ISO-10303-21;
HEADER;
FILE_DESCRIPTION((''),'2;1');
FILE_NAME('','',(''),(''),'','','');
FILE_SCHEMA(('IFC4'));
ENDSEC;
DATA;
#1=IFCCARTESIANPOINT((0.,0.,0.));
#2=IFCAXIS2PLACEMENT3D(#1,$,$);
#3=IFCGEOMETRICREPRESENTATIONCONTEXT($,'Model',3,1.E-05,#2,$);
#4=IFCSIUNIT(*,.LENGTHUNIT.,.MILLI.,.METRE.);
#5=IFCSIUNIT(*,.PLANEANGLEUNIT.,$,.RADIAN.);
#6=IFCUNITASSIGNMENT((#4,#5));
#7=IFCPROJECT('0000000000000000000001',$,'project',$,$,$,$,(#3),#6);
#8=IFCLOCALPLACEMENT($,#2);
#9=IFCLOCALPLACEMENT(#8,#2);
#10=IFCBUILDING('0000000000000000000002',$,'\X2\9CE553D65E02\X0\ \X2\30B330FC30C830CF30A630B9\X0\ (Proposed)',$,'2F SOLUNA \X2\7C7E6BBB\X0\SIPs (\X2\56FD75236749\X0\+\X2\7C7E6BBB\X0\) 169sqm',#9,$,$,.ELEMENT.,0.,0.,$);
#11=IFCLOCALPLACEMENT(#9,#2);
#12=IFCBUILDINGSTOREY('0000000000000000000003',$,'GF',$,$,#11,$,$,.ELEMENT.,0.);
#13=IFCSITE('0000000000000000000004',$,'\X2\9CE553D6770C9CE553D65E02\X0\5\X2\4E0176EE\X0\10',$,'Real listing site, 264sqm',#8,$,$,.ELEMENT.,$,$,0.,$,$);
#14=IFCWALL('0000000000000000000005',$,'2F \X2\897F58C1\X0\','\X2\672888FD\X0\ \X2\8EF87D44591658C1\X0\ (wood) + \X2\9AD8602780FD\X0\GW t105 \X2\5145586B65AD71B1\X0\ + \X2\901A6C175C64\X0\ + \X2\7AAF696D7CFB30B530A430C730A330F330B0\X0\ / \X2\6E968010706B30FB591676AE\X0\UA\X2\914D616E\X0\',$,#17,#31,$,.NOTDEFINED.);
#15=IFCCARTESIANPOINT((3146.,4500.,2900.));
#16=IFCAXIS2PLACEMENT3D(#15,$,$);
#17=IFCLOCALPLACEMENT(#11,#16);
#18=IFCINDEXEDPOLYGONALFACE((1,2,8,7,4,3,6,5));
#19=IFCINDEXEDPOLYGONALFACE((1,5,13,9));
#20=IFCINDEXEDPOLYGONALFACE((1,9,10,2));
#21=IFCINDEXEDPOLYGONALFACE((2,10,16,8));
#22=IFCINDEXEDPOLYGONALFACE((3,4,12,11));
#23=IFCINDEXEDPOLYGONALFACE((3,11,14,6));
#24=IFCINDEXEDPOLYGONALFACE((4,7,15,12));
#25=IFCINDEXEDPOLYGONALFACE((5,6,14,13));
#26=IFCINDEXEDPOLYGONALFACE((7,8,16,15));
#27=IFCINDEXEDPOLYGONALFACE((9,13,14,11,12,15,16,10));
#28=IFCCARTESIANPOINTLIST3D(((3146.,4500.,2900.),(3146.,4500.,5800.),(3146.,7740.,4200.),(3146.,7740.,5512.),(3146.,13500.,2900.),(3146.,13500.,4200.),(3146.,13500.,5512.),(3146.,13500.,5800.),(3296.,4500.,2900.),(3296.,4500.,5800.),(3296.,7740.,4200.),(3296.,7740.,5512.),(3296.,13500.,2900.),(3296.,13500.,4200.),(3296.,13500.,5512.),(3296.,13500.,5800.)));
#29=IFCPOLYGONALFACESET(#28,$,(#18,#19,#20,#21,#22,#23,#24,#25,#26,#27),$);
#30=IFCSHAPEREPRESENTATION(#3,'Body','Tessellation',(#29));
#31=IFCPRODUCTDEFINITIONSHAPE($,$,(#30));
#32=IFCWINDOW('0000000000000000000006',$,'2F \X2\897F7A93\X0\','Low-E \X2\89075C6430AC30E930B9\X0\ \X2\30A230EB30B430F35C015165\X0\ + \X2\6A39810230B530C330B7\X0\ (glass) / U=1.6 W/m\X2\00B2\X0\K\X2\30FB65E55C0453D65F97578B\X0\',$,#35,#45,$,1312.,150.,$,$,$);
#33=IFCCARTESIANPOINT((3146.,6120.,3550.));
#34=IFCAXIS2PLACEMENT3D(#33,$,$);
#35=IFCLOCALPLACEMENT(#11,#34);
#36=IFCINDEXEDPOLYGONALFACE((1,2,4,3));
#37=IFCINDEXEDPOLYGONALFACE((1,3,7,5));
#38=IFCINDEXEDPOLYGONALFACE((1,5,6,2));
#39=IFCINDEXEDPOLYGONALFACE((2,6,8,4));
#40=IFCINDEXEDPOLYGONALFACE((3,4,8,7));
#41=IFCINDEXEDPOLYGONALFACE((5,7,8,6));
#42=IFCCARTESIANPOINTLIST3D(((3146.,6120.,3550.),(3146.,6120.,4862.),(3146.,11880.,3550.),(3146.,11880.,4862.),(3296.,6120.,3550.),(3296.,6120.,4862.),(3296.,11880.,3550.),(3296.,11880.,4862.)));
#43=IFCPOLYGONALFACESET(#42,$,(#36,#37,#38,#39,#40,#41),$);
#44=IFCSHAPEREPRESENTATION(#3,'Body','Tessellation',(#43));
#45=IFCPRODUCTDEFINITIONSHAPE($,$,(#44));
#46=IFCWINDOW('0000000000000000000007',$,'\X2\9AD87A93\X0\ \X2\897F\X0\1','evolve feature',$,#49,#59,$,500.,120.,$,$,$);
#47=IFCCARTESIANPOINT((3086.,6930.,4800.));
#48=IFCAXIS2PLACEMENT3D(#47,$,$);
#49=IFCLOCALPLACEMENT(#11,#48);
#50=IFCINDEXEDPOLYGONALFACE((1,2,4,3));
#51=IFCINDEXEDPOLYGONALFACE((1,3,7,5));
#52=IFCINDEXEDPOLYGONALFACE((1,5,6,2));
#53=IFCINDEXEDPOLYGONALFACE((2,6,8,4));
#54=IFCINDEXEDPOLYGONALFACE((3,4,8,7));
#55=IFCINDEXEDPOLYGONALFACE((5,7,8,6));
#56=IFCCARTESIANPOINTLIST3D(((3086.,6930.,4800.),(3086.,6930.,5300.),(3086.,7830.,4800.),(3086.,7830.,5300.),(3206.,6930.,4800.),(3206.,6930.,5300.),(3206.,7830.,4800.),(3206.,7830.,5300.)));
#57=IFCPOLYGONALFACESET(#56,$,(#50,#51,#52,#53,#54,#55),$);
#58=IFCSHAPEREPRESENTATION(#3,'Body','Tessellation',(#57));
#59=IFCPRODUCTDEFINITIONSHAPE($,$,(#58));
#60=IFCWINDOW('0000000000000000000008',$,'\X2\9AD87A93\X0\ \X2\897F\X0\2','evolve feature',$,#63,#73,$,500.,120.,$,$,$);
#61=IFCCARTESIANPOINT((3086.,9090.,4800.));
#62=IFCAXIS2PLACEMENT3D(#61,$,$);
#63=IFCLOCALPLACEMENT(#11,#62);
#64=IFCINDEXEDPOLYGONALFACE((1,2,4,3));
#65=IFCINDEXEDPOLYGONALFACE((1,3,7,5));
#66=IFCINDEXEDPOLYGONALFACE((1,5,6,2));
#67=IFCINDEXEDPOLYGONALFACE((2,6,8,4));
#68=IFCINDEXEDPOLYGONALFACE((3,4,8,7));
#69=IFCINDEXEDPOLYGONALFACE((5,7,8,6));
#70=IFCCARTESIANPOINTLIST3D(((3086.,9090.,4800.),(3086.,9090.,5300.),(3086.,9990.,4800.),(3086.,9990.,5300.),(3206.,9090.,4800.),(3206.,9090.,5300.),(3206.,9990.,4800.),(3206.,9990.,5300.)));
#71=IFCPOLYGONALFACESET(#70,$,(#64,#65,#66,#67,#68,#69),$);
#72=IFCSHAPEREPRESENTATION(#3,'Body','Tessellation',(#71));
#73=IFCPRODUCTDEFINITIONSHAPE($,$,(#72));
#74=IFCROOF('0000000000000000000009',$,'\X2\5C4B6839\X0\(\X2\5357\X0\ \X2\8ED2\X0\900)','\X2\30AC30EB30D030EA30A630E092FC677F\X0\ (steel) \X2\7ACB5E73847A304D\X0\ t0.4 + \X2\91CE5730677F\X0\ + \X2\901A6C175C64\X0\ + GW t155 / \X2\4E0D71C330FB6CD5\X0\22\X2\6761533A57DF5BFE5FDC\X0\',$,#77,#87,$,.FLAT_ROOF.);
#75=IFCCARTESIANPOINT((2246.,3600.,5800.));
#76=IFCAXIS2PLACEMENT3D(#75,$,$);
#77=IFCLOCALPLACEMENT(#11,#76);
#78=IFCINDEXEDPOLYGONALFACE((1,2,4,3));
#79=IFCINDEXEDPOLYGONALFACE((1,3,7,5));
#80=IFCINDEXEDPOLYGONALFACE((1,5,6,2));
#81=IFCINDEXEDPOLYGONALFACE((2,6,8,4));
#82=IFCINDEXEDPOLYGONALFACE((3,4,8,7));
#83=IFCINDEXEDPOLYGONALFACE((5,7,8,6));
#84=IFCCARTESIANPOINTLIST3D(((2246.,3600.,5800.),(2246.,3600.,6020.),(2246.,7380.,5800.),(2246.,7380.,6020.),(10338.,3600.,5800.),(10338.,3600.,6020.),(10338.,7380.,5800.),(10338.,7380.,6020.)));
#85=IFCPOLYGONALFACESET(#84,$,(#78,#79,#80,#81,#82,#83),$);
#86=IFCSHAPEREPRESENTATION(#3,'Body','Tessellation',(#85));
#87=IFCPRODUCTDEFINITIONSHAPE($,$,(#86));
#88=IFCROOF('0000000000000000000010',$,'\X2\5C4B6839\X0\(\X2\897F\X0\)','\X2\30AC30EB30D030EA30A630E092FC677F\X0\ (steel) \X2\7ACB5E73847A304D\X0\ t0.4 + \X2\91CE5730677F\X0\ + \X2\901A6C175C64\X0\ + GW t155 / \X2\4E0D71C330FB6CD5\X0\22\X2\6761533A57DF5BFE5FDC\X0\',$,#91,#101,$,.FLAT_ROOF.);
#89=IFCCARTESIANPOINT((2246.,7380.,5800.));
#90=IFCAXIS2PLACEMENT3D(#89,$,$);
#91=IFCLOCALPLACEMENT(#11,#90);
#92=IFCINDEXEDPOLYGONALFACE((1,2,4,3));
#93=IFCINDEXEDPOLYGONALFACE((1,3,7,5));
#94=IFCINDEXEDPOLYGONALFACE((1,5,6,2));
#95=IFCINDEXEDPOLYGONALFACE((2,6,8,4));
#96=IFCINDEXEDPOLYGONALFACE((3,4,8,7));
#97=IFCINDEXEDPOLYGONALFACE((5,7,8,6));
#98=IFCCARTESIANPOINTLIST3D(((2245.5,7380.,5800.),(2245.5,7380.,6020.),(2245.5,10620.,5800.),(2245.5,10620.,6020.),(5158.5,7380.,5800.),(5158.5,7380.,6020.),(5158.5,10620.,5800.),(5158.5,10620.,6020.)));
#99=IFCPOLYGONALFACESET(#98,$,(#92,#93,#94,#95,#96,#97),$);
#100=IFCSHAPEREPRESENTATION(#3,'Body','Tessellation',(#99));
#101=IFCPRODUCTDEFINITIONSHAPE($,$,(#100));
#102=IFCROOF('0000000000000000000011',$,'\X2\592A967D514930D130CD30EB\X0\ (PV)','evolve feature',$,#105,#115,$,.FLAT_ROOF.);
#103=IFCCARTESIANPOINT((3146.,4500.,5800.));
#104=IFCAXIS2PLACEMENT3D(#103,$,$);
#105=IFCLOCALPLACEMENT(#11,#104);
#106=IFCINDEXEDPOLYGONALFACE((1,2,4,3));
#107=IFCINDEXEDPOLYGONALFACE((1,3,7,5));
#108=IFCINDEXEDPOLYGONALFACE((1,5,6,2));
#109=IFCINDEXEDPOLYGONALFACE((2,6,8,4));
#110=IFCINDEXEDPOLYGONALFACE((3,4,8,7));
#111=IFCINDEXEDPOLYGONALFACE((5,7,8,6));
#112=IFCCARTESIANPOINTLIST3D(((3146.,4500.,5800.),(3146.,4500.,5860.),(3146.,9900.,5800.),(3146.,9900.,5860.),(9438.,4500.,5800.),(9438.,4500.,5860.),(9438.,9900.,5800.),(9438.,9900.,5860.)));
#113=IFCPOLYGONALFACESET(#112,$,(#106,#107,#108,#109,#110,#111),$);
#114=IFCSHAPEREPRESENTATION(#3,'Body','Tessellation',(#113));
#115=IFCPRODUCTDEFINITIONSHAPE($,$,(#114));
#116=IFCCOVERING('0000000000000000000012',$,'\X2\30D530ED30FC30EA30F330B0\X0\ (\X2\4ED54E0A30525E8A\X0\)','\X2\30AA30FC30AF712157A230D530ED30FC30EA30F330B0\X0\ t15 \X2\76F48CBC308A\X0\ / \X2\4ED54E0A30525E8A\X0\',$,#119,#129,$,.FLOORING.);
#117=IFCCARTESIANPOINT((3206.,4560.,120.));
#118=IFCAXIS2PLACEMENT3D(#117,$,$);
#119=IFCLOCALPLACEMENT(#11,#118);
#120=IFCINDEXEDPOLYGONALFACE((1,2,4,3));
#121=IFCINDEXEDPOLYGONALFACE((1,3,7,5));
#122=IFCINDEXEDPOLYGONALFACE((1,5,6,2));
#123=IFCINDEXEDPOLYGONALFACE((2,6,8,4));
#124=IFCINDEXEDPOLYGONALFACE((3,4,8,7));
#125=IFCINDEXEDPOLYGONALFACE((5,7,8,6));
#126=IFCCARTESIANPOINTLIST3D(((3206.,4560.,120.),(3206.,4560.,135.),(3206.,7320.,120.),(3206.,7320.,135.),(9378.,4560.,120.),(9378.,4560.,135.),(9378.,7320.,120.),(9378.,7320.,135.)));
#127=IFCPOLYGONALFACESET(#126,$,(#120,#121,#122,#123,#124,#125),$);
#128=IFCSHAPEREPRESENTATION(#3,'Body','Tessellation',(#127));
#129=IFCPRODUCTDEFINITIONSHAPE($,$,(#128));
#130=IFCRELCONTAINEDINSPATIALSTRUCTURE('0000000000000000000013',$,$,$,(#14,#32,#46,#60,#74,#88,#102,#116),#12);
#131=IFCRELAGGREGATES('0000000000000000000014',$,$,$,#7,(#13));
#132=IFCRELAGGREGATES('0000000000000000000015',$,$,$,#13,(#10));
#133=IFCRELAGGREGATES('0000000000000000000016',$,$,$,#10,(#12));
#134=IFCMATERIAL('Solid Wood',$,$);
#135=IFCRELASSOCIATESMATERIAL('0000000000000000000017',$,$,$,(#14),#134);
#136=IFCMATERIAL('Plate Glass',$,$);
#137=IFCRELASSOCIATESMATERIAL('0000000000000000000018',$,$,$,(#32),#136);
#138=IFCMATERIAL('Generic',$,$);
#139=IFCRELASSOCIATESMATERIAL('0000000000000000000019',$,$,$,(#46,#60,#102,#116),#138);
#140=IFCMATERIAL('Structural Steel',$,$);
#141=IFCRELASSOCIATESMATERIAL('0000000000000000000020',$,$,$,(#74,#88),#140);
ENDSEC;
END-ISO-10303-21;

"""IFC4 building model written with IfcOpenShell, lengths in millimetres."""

from ifc_helpers import new_model, si_unit, frame, frame_2d, origin, place, context, project, spatial, rectangle, extrude, material, element, fill, save


model = new_model("IFC4")

# Units and contexts
model_context = context("Model", 3, precision=1e-05, world=origin())
ifc_project = project(units=[si_unit("LENGTHUNIT", "METRE", prefix="MILLI"), si_unit("PLANEANGLEUNIT", "RADIAN")], contexts=[model_context])

# Site, building, storey
site_placement = place(None, origin())
site = spatial("IfcSite", under=ifc_project, at=site_placement, Name="鳥取県鳥取市5丁目10", ObjectType="Real listing site, 264sqm", CompositionType="ELEMENT", RefElevation=0.0)
building_placement = place(site_placement, origin())
building = spatial("IfcBuilding", under=site, at=building_placement, Name="鳥取市 コートハウス (Proposed)", ObjectType="2F SOLUNA 籾殻SIPs (国産杉+籾殻) 169sqm", CompositionType="ELEMENT", ElevationOfRefHeight=0.0, ElevationOfTerrain=0.0)
storey_placement = place(building_placement, origin())
storey = spatial("IfcBuildingStorey", under=building, at=storey_placement, Name="GF", CompositionType="ELEMENT", Elevation=0.0)

# Shared definitions
ifc_material_1 = material(Name="Solid Wood")
ifc_material_2 = material(Name="Generic")

# Shared definitions
ifc_material_3 = material(Name="Plate Glass")

# Wall, openings, windows
wall_1_placement = place(storey_placement, frame((3146.0, 4500.0, 2900.0)))
wall_1 = element("IfcWall", 1, at=wall_1_placement, inside=storey, material=ifc_material_1, Name="2F 西壁", Description="木製 軸組外壁 (wood) + 高性能GW t105 充填断熱 + 通気層 + 窯業系サイディング / 準耐火・外皮UA配慮", PredefinedType="NOTDEFINED", context=model_context, shape_type="SweptSolid", body=[
    extrude(rectangle(XDim=150.0, YDim=9000.0, at=frame_2d((75.0, 4500.0))), frame((3146.0, 4500.0, 2900.0)), (0.0, 0.0, 1.0), 2900.0),
])
opening_1_placement = place(storey_placement, frame((3146.0, 6120.0, 3550.0)))
opening_1 = element("IfcOpeningElement", 2, at=opening_1_placement, cuts=wall_1, PredefinedType="NOTDEFINED", context=model_context, shape_type="SweptSolid", body=[
    extrude(rectangle(XDim=150.0, YDim=5760.0, at=frame_2d((75.0, 2880.0))), frame((3146.0, 6120.0, 3550.0)), (0.0, 0.0, 1.0), 1312.0),
])
opening_2_placement = place(storey_placement, frame((3086.0, 6930.0, 4800.0)))
opening_2 = element("IfcOpeningElement", 3, at=opening_2_placement, cuts=wall_1, PredefinedType="NOTDEFINED", context=model_context, shape_type="SweptSolid", body=[
    extrude(rectangle(XDim=120.0, YDim=900.0, at=frame_2d((60.0, 450.0))), frame((3086.0, 6930.0, 4800.0)), (0.0, 0.0, 1.0), 500.0),
])
opening_3_placement = place(storey_placement, frame((3086.0, 9090.0, 4800.0)))
opening_3 = element("IfcOpeningElement", 4, at=opening_3_placement, cuts=wall_1, PredefinedType="NOTDEFINED", context=model_context, shape_type="SweptSolid", body=[
    extrude(rectangle(XDim=120.0, YDim=900.0, at=frame_2d((60.0, 450.0))), frame((3086.0, 9090.0, 4800.0)), (0.0, 0.0, 1.0), 500.0),
])
window_1_placement = place(storey_placement, frame((3146.0, 6120.0, 3550.0)))
window_1 = element("IfcWindow", 5, at=window_1_placement, inside=storey, material=ifc_material_3, Name="2F 西窓", Description="Low-E 複層ガラス アルゴン封入 + 樹脂サッシ (glass) / U=1.6 W/m²K・日射取得型", OverallHeight=1312.0, OverallWidth=150.0, context=model_context, shape_type="SweptSolid", body=[
    extrude(rectangle(XDim=150.0, YDim=5760.0, at=frame_2d((75.0, 2880.0))), frame((3146.0, 6120.0, 3550.0)), (0.0, 0.0, 1.0), 1312.0),
])
fill(opening_1, window_1)
window_2_placement = place(storey_placement, frame((3086.0, 6930.0, 4800.0)))
window_2 = element("IfcWindow", 6, at=window_2_placement, inside=storey, material=ifc_material_2, Name="高窓 西1", Description="evolve feature", OverallHeight=500.0, OverallWidth=120.0, context=model_context, shape_type="SweptSolid", body=[
    extrude(rectangle(XDim=120.0, YDim=900.0, at=frame_2d((60.0, 450.0))), frame((3086.0, 6930.0, 4800.0)), (0.0, 0.0, 1.0), 500.0),
])
fill(opening_2, window_2)
window_3_placement = place(storey_placement, frame((3086.0, 9090.0, 4800.0)))
window_3 = element("IfcWindow", 7, at=window_3_placement, inside=storey, material=ifc_material_2, Name="高窓 西2", Description="evolve feature", OverallHeight=500.0, OverallWidth=120.0, context=model_context, shape_type="SweptSolid", body=[
    extrude(rectangle(XDim=120.0, YDim=900.0, at=frame_2d((60.0, 450.0))), frame((3086.0, 9090.0, 4800.0)), (0.0, 0.0, 1.0), 500.0),
])
fill(opening_3, window_3)

# Roofs
ifc_material_4 = material(Name="Structural Steel")
roof_1_placement = place(storey_placement, frame((2246.0, 3600.0, 5800.0)))
element("IfcRoof", 8, at=roof_1_placement, inside=storey, material=ifc_material_4, Name="屋根(南 軒900)", Description="ガルバリウム鋼板 (steel) 立平葺き t0.4 + 野地板 + 通気層 + GW t155 / 不燃・法22条区域対応", PredefinedType="FLAT_ROOF", context=model_context, shape_type="SweptSolid", body=[
    extrude(rectangle(XDim=8092.0, YDim=3780.0, at=frame_2d((4046.0, 1890.0))), frame((2246.0, 3600.0, 5800.0)), (0.0, 0.0, 1.0), 220.0),
])
roof_2_placement = place(storey_placement, frame((2246.0, 7380.0, 5800.0)))
element("IfcRoof", 9, at=roof_2_placement, inside=storey, material=ifc_material_4, Name="屋根(西)", Description="ガルバリウム鋼板 (steel) 立平葺き t0.4 + 野地板 + 通気層 + GW t155 / 不燃・法22条区域対応", PredefinedType="FLAT_ROOF", context=model_context, shape_type="SweptSolid", body=[
    extrude(rectangle(XDim=2913.0, YDim=3240.0, at=frame_2d((1456.0, 1620.0))), frame((2246.0, 7380.0, 5800.0)), (0.0, 0.0, 1.0), 220.0),
])
roof_3_placement = place(storey_placement, frame((3146.0, 4500.0, 5800.0)))
element("IfcRoof", 10, at=roof_3_placement, inside=storey, material=ifc_material_2, Name="太陽光パネル (PV)", Description="evolve feature", PredefinedType="FLAT_ROOF", context=model_context, shape_type="SweptSolid", body=[
    extrude(rectangle(XDim=6292.0, YDim=5400.0, at=frame_2d((3146.0, 2700.0))), frame((3146.0, 4500.0, 5800.0)), (0.0, 0.0, 1.0), 60.0),
])

# Covering
covering_placement = place(storey_placement, frame((3206.0, 4560.0, 120.0)))
element("IfcCovering", 11, at=covering_placement, inside=storey, material=ifc_material_2, Name="フローリング (仕上げ床)", Description="オーク無垢フローリング t15 直貼り / 仕上げ床", PredefinedType="FLOORING", context=model_context, shape_type="SweptSolid", body=[
    extrude(rectangle(XDim=6172.0, YDim=2760.0, at=frame_2d((3086.0, 1380.0))), frame((3206.0, 4560.0, 120.0)), (0.0, 0.0, 1.0), 15.0),
])

save(model, "model.ifc")
